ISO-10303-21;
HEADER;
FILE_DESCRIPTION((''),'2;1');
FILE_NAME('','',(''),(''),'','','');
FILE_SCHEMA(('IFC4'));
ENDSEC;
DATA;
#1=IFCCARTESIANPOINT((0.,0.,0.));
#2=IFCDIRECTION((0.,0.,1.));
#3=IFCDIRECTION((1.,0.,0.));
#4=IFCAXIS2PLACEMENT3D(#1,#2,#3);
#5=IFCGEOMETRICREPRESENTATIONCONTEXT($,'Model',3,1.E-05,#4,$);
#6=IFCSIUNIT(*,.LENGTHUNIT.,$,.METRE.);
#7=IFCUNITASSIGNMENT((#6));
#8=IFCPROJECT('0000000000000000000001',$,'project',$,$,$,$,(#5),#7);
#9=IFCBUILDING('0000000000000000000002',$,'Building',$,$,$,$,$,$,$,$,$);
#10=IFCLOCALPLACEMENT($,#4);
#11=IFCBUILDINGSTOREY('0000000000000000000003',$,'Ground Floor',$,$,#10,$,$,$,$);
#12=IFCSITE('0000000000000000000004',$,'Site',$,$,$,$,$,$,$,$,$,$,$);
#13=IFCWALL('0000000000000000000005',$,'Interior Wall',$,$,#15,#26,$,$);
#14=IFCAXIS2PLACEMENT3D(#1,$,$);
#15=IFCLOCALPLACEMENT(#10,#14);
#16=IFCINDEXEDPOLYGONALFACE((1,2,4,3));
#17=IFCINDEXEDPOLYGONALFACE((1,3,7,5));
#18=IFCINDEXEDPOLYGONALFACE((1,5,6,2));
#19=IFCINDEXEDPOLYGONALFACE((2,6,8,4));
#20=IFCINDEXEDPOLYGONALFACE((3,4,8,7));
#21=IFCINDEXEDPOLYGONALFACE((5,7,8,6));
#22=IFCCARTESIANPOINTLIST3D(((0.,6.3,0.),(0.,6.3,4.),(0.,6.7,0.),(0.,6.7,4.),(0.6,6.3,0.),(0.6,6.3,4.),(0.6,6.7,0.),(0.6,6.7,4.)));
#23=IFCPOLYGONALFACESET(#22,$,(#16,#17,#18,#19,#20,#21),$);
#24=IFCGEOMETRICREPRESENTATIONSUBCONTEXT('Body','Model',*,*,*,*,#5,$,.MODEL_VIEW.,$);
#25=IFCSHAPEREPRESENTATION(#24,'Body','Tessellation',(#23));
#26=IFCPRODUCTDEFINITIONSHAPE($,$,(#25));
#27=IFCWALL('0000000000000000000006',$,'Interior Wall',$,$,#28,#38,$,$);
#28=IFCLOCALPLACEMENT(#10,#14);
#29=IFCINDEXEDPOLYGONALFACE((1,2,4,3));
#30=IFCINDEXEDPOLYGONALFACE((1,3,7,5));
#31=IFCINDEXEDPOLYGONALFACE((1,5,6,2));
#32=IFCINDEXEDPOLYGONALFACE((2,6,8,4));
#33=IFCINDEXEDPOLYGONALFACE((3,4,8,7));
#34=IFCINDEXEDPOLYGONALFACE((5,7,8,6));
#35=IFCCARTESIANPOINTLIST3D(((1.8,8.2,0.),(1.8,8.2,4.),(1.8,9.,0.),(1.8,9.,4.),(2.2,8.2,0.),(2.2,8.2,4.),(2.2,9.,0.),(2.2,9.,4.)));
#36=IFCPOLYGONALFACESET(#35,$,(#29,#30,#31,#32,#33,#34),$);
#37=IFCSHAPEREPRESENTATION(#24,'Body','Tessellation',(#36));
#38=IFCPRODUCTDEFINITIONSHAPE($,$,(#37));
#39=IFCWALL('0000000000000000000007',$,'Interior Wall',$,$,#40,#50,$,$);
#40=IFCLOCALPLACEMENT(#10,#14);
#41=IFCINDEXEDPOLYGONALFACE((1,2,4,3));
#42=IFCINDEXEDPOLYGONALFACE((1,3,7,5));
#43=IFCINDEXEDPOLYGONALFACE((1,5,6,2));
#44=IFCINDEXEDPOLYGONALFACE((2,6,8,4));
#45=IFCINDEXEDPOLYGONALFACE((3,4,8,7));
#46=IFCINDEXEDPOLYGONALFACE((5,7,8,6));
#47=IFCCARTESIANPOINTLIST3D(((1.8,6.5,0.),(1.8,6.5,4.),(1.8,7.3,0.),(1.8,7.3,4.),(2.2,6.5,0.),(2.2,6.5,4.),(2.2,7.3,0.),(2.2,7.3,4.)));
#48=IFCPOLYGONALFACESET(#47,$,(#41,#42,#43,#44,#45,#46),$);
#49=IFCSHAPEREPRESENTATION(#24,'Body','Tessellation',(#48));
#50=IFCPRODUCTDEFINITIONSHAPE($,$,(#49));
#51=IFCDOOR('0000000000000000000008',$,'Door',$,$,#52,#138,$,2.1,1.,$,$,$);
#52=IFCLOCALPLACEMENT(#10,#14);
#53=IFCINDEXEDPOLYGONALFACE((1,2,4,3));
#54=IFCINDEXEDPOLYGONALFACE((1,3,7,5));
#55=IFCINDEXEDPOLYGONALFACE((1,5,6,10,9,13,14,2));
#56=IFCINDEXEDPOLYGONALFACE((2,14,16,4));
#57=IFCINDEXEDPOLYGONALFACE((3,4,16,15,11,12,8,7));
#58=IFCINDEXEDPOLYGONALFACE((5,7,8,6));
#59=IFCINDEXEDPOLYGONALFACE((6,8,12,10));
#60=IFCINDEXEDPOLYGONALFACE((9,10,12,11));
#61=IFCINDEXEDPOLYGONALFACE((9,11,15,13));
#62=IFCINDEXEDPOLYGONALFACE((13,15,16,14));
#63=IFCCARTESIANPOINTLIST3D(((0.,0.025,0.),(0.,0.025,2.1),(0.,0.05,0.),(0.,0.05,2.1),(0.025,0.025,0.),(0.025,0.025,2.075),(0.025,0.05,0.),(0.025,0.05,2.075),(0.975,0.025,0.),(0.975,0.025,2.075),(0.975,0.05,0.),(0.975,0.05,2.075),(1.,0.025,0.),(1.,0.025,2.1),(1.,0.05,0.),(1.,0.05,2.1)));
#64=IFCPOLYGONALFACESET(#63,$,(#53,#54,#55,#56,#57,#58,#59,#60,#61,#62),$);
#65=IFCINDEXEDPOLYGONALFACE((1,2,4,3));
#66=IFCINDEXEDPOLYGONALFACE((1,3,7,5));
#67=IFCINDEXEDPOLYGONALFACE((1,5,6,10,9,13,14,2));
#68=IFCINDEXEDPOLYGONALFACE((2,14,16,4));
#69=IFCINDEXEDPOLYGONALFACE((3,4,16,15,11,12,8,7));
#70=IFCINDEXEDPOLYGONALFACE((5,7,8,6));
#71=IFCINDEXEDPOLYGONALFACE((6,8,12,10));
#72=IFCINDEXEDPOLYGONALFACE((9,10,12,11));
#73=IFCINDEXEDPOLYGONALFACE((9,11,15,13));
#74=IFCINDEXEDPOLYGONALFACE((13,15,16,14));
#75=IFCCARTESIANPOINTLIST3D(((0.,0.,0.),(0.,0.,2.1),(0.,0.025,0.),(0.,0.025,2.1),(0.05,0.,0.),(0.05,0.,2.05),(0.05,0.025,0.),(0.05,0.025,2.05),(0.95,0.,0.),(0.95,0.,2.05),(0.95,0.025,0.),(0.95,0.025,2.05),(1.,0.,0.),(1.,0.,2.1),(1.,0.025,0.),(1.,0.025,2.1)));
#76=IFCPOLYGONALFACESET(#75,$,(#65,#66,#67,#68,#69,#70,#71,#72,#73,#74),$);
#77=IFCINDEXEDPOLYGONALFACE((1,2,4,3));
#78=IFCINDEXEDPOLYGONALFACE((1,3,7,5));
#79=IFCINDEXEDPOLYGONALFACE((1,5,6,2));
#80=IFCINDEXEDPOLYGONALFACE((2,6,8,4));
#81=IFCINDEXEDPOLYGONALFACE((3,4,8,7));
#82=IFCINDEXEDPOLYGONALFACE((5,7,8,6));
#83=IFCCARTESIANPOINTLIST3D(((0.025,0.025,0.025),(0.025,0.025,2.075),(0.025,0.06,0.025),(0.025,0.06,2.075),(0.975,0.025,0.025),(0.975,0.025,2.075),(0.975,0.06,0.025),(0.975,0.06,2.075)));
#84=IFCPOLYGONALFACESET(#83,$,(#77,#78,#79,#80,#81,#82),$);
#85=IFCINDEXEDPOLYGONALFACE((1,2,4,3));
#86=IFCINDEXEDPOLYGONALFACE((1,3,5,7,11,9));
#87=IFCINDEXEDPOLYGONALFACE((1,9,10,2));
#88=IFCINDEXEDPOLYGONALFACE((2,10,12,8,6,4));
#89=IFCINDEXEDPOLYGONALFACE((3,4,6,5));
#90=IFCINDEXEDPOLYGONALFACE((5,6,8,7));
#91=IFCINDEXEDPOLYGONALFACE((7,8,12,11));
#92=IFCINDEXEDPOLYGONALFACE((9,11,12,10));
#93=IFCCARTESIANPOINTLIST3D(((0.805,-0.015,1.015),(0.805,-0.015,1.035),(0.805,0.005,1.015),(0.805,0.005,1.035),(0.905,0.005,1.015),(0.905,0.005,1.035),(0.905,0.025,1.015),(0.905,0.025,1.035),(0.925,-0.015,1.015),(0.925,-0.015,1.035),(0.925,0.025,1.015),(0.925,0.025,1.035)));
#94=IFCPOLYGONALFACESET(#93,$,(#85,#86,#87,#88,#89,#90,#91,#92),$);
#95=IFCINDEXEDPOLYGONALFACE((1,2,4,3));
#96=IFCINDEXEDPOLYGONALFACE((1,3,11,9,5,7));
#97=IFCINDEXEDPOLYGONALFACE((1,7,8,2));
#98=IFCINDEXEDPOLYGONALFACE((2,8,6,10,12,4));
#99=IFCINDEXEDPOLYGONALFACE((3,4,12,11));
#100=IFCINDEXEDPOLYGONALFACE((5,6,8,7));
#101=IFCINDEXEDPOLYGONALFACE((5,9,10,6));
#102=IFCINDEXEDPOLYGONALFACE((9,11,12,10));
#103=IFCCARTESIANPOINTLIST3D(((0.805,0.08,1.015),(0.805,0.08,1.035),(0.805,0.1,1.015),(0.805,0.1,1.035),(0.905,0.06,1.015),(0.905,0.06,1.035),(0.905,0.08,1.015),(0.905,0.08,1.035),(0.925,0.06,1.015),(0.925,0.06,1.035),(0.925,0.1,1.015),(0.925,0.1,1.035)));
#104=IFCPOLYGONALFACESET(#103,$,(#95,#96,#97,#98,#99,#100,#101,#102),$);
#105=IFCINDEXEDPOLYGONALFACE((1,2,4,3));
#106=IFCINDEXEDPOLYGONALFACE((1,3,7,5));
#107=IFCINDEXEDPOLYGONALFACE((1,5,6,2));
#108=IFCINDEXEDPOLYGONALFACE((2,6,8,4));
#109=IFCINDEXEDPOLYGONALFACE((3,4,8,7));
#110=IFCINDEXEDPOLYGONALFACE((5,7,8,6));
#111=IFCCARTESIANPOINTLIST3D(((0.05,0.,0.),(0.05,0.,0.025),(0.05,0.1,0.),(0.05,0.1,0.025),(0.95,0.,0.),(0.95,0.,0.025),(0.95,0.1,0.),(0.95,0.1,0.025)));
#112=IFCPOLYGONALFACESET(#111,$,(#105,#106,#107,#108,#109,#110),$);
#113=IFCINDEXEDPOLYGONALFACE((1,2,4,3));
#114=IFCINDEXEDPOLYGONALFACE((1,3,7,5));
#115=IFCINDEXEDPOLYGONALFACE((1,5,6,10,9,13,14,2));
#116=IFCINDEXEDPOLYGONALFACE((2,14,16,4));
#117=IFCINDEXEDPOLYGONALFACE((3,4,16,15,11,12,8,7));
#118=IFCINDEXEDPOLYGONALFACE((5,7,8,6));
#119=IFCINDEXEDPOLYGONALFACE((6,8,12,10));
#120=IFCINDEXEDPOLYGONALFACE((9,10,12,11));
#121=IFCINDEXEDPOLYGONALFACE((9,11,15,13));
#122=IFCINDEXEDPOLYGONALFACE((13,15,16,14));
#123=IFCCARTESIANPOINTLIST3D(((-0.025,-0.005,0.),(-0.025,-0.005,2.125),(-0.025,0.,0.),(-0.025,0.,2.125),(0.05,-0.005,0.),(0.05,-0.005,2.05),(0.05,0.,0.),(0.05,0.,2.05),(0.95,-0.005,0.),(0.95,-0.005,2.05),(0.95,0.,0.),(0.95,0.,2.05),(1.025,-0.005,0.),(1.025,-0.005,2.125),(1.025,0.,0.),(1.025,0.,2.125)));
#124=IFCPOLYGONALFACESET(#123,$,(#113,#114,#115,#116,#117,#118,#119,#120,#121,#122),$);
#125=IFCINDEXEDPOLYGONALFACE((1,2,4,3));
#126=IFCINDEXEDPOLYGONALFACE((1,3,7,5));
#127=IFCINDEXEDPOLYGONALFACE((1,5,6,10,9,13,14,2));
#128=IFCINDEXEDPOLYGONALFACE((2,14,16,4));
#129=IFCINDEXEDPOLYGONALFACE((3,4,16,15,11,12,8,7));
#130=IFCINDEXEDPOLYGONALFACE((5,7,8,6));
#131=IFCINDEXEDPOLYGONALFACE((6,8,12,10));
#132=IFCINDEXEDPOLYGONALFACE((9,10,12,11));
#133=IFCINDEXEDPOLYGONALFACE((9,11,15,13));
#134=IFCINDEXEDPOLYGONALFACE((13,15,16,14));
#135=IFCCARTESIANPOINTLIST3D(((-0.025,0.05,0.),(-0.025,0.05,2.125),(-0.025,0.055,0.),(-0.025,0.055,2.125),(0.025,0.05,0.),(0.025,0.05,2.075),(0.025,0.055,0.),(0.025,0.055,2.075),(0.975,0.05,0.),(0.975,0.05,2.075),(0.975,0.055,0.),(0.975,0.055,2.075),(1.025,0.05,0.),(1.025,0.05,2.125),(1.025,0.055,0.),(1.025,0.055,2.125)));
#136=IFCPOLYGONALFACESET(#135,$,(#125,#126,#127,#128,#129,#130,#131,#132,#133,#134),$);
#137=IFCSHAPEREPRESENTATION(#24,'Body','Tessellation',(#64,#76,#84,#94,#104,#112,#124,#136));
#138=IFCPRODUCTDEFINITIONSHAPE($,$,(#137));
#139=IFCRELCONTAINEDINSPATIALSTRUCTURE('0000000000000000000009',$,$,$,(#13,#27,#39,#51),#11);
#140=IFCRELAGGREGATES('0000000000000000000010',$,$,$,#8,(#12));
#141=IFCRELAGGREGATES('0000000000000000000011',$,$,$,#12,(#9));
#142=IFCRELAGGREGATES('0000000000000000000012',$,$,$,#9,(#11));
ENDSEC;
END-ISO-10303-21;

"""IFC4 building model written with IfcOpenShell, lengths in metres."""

from ifc_helpers import new_model, si_unit, frame, origin_with_axes, place, context, subcontext, project, spatial, line, indexed_curve, outline, extrude, element, save


model = new_model("IFC4")

# Units and contexts
model_context = context("Model", 3, precision=1e-05, world=origin_with_axes())
body_context = subcontext(model_context, "Body", "Model", "MODEL_VIEW")
ifc_project = project(units=[si_unit("LENGTHUNIT", "METRE")], contexts=[model_context])

# Site, building, storey
site = spatial("IfcSite", under=ifc_project, Name="Site")
building = spatial("IfcBuilding", under=site, Name="Building")
storey_placement = place(None, origin_with_axes())
storey = spatial("IfcBuildingStorey", under=building, at=storey_placement, Name="Ground Floor")

# Walls
for number, where, z_axis, x_axis, name in (
    (1, (0.6, 6.5, 0.0), (0.0, 0.0, 1.0), (-1.0, 0.0, 0.0), "Interior Wall"),
):
    element("IfcWall", number, at=place(storey_placement, frame(where, z_axis=z_axis, x_axis=x_axis)), inside=storey, Name=name, context=body_context, shape_type="SweptSolid", body=[
        extrude(outline(indexed_curve([(0.0, 0.0), (0.0, 0.4), (0.6, 0.4), (0.6, 0.0), (0.0, 0.0)], self_intersect=False)), frame((0.0, -0.2, 0.0), z_axis=(0.0, 0.0, 1.0), x_axis=(1.0, 0.0, 0.0)), (0.0, 0.0, 1.0), 4.0),
    ])
wall_1_placement = place(storey_placement, frame((2.0, 9.0, 0.0), z_axis=(0.0, 0.0, 1.0), x_axis=(0.0, -1.0, 0.0)))
element("IfcWall", 2, at=wall_1_placement, inside=storey, Name="Interior Wall", context=body_context, shape_type="SweptSolid", body=[
    extrude(outline(indexed_curve([(0.0, 0.0), (0.0, 0.4), (0.8, 0.4), (0.8, 0.0), (0.0, 0.0)], self_intersect=False)), frame((0.0, -0.2, 0.0), z_axis=(0.0, 0.0, 1.0), x_axis=(1.0, 0.0, 0.0)), (0.0, 0.0, 1.0), 4.0),
])
wall_2_placement = place(storey_placement, frame((2.0, 7.3, 0.0), z_axis=(0.0, 0.0, 1.0), x_axis=(0.0, -1.0, 0.0)))
element("IfcWall", 3, at=wall_2_placement, inside=storey, Name="Interior Wall", context=body_context, shape_type="SweptSolid", body=[
    extrude(outline(indexed_curve([(0.0, 0.0), (0.0, 0.4), (0.8, 0.4), (0.8, 0.0), (0.0, 0.0)], self_intersect=False)), frame((0.0, -0.2, 0.0), z_axis=(0.0, 0.0, 1.0), x_axis=(1.0, 0.0, 0.0)), (0.0, 0.0, 1.0), 4.0),
])

# Door
door_1_placement = place(storey_placement, origin_with_axes())
element("IfcDoor", 4, at=door_1_placement, inside=storey, Name="Door", OverallHeight=2.1, OverallWidth=1.0, context=body_context, shape_type="SweptSolid", body=[
    extrude(outline(indexed_curve([(0.0, 0.0), (0.0, 2.1), (1.0, 2.1), (1.0, 0.0), (0.975, 0.0), (0.975, 2.075), (0.025, 2.075), (0.025, 0.0)], segments=[line(1, 2, 3, 4, 5, 6, 7, 8, 1)])), frame((0.0, 0.025, 0.0), z_axis=(0.0, -1.0, 0.0), x_axis=(1.0, 0.0, 0.0)), (0.0, 0.0, -1.0), 0.025),
    extrude(outline(indexed_curve([(0.0, 0.0), (0.0, 2.1), (1.0, 2.1), (1.0, 0.0), (0.95, 0.0), (0.95, 2.05), (0.05, 2.05), (0.05, 0.0)], segments=[line(1, 2, 3, 4, 5, 6, 7, 8, 1)])), frame((0.0, 0.0, 0.0), z_axis=(0.0, -1.0, 0.0), x_axis=(1.0, 0.0, 0.0)), (0.0, 0.0, -1.0), 0.025),
    extrude(outline(indexed_curve([(0.0, 0.0), (0.95, 0.0), (0.95, 0.035), (0.0, 0.035)], segments=[line(1, 2, 3, 4, 1)])), frame((0.025, 0.025, 0.025), z_axis=(0.0, 0.0, 1.0), x_axis=(1.0, 0.0, 0.0)), (0.0, 0.0, 1.0), 2.05),
    extrude(outline(indexed_curve([(0.0, 0.0), (0.0, -0.04), (-0.12, -0.04), (-0.12, -0.02), (-0.02, -0.02), (-0.02, 0.0)], segments=[line(1, 2, 3, 4, 5, 6, 1)])), frame((0.925, 0.025, 1.015), z_axis=(0.0, 0.0, 1.0), x_axis=(1.0, 0.0, 0.0)), (0.0, 0.0, 1.0), 0.02),
    extrude(outline(indexed_curve([(0.0, 0.0), (0.0, 0.04), (-0.12, 0.04), (-0.12, 0.02), (-0.02, 0.02), (-0.02, 0.0)], segments=[line(1, 2, 3, 4, 5, 6, 1)])), frame((0.925, 0.06, 1.015), z_axis=(0.0, 0.0, 1.0), x_axis=(1.0, 0.0, 0.0)), (0.0, 0.0, 1.0), 0.02),
    extrude(outline(indexed_curve([(0.0, 0.0), (0.9, 0.0), (0.9, 0.1), (0.0, 0.1)], segments=[line(1, 2, 3, 4, 1)])), frame((0.05, 0.0, 0.0), z_axis=(0.0, 0.0, 1.0), x_axis=(1.0, 0.0, 0.0)), (0.0, 0.0, 1.0), 0.025),
    extrude(outline(indexed_curve([(0.0, 0.0), (0.0, 2.125), (1.05, 2.125), (1.05, 0.0), (0.975, 0.0), (0.975, 2.05), (0.075, 2.05), (0.075, 0.0)], segments=[line(1, 2, 3, 4, 5, 6, 7, 8, 1)])), frame((-0.025, -0.005, 0.0), z_axis=(0.0, -1.0, 0.0), x_axis=(1.0, 0.0, 0.0)), (0.0, 0.0, -1.0), 0.005),
    extrude(outline(indexed_curve([(0.0, 0.0), (0.0, 2.125), (1.05, 2.125), (1.05, 0.0), (1.0, 0.0), (1.0, 2.075), (0.05, 2.075), (0.05, 0.0)], segments=[line(1, 2, 3, 4, 5, 6, 7, 8, 1)])), frame((-0.025, 0.05, 0.0), z_axis=(0.0, -1.0, 0.0), x_axis=(1.0, 0.0, 0.0)), (0.0, 0.0, -1.0), 0.005),
])

save(model, "model.ifc")
